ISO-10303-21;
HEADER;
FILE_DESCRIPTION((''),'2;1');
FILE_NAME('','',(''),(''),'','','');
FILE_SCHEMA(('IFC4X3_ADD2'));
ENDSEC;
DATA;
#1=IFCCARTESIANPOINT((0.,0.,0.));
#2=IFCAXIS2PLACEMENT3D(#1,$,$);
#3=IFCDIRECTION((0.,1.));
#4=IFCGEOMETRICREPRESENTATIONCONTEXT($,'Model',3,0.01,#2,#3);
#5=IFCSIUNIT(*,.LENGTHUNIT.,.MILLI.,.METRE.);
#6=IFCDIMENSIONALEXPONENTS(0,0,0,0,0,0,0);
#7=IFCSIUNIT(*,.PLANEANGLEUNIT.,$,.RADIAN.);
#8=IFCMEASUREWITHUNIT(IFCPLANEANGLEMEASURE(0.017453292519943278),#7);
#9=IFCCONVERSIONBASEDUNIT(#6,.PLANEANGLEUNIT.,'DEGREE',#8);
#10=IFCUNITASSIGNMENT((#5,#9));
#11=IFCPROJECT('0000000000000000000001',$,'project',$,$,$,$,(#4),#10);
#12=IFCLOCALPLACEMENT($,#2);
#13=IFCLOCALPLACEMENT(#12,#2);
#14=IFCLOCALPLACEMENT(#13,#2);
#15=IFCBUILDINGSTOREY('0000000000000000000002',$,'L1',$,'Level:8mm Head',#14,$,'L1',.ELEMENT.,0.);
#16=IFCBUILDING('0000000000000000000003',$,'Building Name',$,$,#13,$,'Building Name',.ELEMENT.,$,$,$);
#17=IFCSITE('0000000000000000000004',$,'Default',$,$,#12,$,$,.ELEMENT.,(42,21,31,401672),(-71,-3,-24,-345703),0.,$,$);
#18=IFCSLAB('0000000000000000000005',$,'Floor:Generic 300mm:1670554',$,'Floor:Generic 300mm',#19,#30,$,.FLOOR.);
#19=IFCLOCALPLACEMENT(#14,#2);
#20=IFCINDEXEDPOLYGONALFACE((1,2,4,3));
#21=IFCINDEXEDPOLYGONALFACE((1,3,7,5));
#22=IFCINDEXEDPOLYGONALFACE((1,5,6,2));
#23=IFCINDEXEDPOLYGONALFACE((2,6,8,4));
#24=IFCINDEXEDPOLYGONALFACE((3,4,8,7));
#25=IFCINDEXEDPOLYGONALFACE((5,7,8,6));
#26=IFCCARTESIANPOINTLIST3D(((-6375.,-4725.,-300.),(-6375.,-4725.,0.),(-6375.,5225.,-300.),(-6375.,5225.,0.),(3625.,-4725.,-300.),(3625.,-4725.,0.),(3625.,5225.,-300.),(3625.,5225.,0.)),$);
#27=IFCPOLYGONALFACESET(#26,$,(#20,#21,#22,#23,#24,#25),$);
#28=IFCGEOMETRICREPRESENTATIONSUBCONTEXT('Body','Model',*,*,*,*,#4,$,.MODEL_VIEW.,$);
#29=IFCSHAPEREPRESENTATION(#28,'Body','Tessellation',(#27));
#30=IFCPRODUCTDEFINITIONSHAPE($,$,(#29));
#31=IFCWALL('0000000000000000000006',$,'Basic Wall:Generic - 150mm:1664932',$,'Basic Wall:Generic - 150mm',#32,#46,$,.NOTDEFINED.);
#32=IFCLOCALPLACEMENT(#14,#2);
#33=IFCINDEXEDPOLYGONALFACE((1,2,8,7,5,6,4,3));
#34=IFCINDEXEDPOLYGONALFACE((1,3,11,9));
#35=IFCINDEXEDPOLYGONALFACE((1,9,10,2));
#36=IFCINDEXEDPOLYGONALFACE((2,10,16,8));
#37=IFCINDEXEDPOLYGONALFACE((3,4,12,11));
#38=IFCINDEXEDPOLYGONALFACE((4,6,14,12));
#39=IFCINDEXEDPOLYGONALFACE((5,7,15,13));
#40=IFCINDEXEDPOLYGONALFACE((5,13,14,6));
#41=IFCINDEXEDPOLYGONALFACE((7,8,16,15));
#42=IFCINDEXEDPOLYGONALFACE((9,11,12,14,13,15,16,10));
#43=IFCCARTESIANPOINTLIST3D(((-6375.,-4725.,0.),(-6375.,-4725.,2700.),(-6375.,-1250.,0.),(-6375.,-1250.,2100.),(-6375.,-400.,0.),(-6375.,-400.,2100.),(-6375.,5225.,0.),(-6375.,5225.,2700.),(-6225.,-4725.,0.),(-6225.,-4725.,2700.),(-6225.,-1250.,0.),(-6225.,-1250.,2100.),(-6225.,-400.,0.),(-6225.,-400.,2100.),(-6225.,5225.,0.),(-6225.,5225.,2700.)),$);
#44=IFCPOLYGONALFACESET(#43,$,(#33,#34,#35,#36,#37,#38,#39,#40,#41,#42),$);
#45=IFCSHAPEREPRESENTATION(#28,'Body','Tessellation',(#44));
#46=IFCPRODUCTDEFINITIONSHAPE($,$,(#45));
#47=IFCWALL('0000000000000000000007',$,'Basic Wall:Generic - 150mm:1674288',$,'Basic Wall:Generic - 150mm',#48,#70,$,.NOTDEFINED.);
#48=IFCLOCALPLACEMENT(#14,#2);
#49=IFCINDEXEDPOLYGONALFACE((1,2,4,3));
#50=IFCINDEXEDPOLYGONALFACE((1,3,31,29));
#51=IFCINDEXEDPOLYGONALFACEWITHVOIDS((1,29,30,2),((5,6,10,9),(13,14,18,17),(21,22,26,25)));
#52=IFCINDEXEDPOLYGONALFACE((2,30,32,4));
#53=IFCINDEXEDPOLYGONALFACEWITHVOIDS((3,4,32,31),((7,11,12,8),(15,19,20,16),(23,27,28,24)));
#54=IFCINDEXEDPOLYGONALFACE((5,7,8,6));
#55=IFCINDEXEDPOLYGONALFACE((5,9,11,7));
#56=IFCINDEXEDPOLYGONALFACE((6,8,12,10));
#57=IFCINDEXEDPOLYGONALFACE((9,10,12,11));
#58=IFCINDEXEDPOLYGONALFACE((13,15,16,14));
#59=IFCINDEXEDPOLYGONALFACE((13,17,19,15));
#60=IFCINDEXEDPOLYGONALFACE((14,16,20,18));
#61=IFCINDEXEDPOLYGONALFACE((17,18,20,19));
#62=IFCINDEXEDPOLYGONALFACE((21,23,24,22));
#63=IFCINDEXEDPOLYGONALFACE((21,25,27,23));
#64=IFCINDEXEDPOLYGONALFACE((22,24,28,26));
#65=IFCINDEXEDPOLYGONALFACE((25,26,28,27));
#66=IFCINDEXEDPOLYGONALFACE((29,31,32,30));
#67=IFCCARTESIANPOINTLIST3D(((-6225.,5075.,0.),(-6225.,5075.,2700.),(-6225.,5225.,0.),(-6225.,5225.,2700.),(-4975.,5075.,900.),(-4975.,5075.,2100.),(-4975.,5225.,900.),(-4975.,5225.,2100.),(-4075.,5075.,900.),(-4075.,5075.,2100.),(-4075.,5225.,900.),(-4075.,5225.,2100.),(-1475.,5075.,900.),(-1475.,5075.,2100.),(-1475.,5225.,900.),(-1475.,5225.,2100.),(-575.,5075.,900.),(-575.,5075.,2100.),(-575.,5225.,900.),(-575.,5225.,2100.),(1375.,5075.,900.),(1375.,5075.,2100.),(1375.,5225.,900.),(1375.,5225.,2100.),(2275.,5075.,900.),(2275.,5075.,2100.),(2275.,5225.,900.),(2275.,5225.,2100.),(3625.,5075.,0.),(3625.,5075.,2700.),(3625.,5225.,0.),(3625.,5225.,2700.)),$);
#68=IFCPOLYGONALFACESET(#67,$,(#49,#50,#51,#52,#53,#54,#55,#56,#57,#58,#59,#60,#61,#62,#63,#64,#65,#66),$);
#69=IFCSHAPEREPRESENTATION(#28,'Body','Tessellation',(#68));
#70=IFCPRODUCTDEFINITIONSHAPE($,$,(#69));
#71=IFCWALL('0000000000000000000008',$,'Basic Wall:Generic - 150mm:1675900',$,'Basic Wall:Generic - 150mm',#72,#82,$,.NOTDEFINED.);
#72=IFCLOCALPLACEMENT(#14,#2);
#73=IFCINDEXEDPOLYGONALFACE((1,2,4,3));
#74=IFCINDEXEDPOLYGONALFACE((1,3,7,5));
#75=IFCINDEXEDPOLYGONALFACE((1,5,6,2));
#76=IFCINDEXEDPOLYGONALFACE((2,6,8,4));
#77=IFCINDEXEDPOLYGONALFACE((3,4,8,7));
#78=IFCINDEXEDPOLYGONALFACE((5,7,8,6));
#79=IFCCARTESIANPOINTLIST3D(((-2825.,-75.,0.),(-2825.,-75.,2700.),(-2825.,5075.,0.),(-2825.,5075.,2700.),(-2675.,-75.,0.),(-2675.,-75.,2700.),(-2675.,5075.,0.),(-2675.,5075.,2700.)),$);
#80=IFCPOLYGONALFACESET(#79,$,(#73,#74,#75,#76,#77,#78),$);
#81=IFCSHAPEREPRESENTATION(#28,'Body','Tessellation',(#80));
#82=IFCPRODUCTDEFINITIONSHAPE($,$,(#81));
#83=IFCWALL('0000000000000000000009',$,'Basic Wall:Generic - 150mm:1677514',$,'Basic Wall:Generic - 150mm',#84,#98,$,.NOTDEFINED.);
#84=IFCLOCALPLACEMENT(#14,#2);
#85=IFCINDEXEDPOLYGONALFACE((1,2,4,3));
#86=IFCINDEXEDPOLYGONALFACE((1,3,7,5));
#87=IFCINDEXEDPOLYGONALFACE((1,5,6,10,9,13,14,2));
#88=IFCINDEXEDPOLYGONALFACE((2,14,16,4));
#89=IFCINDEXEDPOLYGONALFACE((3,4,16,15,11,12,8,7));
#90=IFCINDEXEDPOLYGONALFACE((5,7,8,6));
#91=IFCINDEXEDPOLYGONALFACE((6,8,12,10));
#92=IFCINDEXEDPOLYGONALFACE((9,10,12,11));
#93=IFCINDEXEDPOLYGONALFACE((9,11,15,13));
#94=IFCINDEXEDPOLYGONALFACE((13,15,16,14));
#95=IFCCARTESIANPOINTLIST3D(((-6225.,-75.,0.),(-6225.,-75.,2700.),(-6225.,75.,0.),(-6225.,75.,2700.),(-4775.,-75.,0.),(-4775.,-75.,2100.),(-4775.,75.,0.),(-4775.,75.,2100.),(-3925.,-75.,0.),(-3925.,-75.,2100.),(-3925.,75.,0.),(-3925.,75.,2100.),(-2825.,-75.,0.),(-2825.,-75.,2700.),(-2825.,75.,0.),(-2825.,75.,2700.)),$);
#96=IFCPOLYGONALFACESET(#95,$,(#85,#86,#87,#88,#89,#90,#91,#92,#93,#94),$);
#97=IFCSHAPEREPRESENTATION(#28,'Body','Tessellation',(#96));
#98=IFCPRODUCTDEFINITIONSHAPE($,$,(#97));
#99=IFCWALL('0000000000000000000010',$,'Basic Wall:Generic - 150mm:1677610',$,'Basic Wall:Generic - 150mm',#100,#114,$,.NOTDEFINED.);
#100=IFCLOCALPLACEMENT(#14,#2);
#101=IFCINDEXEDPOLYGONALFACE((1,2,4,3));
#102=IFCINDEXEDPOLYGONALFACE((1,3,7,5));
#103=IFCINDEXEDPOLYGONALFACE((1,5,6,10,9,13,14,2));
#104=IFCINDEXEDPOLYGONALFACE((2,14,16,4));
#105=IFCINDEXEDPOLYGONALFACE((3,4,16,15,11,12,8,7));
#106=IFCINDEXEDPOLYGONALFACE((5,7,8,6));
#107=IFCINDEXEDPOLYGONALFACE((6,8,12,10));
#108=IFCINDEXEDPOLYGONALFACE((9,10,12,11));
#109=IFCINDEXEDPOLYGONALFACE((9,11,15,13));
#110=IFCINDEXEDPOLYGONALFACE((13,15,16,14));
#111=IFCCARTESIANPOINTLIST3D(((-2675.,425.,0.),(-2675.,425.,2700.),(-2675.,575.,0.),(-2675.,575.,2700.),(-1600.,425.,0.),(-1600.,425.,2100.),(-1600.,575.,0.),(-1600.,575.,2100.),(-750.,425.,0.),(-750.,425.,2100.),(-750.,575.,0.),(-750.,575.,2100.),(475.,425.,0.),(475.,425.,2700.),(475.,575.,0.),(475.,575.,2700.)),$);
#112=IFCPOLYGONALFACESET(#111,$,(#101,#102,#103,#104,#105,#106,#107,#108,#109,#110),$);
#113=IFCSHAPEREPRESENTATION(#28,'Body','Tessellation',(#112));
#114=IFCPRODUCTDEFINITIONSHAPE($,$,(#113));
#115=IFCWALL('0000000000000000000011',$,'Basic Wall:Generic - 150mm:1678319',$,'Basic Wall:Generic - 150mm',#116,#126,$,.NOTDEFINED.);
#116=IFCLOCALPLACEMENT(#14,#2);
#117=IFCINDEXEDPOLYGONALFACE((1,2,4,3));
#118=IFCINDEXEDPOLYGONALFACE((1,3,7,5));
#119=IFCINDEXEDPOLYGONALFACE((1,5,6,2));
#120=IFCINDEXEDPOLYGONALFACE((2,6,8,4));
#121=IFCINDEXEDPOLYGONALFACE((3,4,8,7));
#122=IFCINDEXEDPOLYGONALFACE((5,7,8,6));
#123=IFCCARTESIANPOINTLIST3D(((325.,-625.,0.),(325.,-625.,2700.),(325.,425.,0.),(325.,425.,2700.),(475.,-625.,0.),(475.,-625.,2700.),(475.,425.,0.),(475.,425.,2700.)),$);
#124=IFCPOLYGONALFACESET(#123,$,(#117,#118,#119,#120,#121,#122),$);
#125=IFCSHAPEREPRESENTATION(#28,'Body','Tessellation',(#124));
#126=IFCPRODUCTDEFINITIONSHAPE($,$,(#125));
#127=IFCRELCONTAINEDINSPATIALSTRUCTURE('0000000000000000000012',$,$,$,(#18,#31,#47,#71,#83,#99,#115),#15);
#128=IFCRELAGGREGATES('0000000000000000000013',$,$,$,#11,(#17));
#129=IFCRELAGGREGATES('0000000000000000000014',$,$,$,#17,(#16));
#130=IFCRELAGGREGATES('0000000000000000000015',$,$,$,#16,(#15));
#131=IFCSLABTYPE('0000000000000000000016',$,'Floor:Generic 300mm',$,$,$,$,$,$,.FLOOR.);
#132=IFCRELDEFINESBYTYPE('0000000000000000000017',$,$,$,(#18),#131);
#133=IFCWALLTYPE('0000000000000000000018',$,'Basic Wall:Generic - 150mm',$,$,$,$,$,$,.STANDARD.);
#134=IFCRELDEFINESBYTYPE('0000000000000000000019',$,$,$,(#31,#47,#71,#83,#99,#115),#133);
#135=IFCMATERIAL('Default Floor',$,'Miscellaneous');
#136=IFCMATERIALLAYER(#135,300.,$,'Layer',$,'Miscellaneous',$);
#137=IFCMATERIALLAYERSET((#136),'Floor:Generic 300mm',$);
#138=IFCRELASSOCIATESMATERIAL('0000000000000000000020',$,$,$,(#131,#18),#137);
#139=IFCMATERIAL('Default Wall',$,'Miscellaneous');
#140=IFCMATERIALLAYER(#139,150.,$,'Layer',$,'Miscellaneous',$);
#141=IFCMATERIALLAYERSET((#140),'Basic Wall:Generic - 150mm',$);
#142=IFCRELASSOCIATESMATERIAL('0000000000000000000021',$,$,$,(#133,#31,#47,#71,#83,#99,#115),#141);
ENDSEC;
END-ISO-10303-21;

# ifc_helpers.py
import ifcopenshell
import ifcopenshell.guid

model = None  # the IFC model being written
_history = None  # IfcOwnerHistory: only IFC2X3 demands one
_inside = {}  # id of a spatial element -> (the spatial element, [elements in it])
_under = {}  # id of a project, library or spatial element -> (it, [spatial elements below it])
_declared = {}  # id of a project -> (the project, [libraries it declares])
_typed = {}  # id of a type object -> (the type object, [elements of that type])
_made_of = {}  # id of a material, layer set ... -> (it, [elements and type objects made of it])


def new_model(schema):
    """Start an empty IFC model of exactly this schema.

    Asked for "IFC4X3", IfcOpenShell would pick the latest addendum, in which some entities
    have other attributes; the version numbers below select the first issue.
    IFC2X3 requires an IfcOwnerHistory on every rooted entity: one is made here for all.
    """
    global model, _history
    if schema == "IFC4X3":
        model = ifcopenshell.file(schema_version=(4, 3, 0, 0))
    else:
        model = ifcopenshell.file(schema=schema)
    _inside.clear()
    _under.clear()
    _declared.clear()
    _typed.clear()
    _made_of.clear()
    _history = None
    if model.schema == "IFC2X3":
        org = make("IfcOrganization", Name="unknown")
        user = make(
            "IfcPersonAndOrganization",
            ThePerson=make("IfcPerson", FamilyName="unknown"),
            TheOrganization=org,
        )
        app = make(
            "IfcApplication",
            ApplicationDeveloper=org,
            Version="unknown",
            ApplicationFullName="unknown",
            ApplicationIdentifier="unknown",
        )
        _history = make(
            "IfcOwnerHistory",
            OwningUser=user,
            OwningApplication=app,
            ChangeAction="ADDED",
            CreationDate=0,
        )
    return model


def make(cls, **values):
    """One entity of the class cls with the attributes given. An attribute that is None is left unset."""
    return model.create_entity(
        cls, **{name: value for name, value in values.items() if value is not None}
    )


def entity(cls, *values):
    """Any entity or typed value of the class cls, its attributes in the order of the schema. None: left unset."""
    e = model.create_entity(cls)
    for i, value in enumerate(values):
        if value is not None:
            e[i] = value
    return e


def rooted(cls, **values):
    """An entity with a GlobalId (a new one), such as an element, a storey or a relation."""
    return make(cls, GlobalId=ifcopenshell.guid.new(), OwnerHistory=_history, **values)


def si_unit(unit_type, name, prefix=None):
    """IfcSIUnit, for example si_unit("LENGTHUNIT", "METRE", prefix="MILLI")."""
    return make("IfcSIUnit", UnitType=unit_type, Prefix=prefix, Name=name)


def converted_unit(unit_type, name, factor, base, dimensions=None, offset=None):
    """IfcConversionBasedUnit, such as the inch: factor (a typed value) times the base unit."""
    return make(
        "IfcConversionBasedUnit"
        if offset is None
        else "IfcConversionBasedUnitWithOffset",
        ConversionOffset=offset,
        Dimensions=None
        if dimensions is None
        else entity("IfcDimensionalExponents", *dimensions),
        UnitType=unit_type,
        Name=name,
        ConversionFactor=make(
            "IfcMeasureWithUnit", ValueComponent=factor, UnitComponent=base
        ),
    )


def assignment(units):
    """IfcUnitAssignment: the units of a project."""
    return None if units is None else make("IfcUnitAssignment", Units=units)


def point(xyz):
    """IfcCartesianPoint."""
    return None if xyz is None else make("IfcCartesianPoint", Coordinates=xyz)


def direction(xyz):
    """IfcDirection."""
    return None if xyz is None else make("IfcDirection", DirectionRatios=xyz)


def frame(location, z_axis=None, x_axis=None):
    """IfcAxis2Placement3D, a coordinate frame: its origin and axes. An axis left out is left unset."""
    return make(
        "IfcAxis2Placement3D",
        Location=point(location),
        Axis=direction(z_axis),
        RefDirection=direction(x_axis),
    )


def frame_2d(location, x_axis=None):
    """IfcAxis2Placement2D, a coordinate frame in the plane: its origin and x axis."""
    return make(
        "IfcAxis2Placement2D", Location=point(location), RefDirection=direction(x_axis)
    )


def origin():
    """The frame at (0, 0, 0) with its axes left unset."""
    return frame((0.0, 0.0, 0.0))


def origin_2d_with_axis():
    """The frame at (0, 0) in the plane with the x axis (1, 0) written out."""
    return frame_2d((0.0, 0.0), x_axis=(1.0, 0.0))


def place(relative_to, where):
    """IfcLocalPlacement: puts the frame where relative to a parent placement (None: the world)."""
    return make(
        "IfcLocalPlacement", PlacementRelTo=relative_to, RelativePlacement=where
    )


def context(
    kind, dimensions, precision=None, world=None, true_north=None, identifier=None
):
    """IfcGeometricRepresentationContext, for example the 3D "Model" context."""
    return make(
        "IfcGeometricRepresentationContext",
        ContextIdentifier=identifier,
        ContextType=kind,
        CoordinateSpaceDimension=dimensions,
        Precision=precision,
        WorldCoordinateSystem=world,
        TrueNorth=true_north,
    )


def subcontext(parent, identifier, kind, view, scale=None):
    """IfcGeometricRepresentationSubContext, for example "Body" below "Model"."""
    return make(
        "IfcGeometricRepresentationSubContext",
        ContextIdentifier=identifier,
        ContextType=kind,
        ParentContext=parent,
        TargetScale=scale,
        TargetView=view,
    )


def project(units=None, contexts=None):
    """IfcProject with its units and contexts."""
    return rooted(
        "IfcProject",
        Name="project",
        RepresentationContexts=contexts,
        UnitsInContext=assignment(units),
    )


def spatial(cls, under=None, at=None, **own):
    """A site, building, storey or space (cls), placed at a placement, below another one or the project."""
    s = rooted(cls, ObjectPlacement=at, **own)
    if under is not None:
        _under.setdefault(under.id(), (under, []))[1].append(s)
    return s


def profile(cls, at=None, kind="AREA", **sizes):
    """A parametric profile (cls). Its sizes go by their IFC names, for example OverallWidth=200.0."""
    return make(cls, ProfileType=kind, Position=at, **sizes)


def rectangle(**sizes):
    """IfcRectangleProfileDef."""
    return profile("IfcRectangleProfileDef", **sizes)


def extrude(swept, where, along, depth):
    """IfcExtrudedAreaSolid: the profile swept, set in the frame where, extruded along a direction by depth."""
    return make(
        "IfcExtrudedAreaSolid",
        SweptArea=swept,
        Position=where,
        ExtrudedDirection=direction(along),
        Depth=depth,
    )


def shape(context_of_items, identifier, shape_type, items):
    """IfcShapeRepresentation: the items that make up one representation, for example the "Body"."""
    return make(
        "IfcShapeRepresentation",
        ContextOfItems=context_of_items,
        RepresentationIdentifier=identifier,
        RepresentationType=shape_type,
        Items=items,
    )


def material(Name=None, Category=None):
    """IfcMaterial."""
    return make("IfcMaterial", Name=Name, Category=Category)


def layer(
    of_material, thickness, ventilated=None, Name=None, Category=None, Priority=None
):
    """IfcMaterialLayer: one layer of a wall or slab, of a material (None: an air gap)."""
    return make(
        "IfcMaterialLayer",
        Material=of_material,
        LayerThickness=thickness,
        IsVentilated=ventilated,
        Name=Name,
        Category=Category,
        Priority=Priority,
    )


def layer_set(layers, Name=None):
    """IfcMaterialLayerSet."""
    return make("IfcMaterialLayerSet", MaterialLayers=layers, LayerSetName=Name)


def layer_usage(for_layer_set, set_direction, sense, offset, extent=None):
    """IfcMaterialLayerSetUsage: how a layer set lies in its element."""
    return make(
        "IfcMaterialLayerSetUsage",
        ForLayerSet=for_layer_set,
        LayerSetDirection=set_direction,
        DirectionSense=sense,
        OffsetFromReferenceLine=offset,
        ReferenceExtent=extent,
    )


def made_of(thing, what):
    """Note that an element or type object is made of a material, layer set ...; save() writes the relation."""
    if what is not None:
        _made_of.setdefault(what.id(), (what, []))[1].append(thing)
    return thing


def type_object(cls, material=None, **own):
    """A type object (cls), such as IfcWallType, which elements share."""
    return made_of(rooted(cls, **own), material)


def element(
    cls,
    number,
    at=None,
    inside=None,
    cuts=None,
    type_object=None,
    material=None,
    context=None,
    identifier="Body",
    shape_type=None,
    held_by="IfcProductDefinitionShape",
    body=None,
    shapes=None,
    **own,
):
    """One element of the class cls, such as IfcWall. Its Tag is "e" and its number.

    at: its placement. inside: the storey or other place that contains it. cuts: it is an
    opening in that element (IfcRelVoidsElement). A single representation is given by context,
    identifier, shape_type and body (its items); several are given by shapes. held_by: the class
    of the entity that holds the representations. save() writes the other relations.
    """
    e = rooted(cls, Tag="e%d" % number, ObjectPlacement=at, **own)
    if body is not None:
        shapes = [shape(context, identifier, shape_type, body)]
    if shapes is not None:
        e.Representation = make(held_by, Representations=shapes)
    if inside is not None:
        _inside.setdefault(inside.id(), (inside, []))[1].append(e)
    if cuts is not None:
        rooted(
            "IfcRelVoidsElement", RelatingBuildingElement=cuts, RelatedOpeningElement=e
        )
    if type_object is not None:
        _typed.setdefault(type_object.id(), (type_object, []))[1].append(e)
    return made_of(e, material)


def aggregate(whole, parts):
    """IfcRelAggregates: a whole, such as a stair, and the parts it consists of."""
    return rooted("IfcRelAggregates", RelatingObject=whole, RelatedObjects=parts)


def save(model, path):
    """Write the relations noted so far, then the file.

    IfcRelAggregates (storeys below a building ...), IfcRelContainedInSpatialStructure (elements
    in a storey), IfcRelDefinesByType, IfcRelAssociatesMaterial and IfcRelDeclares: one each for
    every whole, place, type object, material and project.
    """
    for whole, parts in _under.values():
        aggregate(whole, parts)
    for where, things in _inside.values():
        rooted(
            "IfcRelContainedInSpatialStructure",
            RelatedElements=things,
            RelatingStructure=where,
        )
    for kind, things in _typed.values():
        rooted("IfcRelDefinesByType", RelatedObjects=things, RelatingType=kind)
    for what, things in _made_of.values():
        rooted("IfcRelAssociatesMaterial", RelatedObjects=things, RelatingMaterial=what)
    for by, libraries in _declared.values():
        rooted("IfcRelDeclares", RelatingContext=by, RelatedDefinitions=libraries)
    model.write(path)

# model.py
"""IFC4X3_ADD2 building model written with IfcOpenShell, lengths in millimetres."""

from ifc_helpers import new_model, entity, si_unit, converted_unit, direction, frame, frame_2d, origin, origin_2d_with_axis, place, context, subcontext, project, spatial, rectangle, extrude, material, layer, layer_set, layer_usage, type_object, element, save


model = new_model("IFC4X3_ADD2")

# Units and contexts
model_context = context("Model", 3, precision=0.01, world=origin(), true_north=direction((0.0, 1.0)))
body_context = subcontext(model_context, "Body", "Model", "MODEL_VIEW")
ifc_project = project(units=[si_unit("LENGTHUNIT", "METRE", prefix="MILLI"), converted_unit("PLANEANGLEUNIT", "DEGREE", entity("IfcPlaneAngleMeasure", 0.017453292519943278), si_unit("PLANEANGLEUNIT", "RADIAN"), dimensions=[0, 0, 0, 0, 0, 0, 0])], contexts=[model_context])

# Site, building, storey
site_placement = place(None, origin())
site = spatial("IfcSite", under=ifc_project, at=site_placement, Name="Default", CompositionType="ELEMENT", RefLatitude=(42, 21, 31, 401672), RefLongitude=(-71, -3, -24, -345703), RefElevation=0.0)
building_placement = place(site_placement, origin())
building = spatial("IfcBuilding", under=site, at=building_placement, Name="Building Name", LongName="Building Name", CompositionType="ELEMENT")
storey_placement = place(building_placement, origin())
storey = spatial("IfcBuildingStorey", under=building, at=storey_placement, Name="L1", ObjectType="Level:8mm Head", LongName="L1", CompositionType="ELEMENT", Elevation=0.0)

# Slab
ifc_material_1 = material(Name="Default Floor", Category="Miscellaneous")
ifc_layer_1 = layer(ifc_material_1, 300.0, Name="Layer", Category="Miscellaneous")
ifc_layer_set_1 = layer_set([ifc_layer_1], Name="Floor:Generic 300mm")
ifc_layer_usage = layer_usage(ifc_layer_set_1, "AXIS3", "POSITIVE", 0.0)
slab_type = type_object("IfcSlabType", Name="Floor:Generic 300mm", PredefinedType="FLOOR", material=ifc_layer_set_1)
slab_placement = place(storey_placement, origin())
element("IfcSlab", 1, at=slab_placement, inside=storey, type_object=slab_type, material=ifc_layer_usage, Name="Floor:Generic 300mm:1670554", ObjectType="Floor:Generic 300mm", PredefinedType="FLOOR", context=body_context, shape_type="SweptSolid", body=[
    extrude(rectangle(XDim=9950.0, YDim=10000.0, at=origin_2d_with_axis()), frame((-1375.0, 250.0, 0.0), z_axis=(0.0, 0.0, -1.0), x_axis=(0.0, 1.0, 0.0)), (0.0, 0.0, 1.0), 300.0),
])

# Wall, opening
ifc_material_2 = material(Name="Default Wall", Category="Miscellaneous")
ifc_layer_2 = layer(ifc_material_2, 150.0, Name="Layer", Category="Miscellaneous")
ifc_layer_set_2 = layer_set([ifc_layer_2], Name="Basic Wall:Generic - 150mm")
wall_type = type_object("IfcWallType", Name="Basic Wall:Generic - 150mm", PredefinedType="STANDARD", material=ifc_layer_set_2)
wall_1_placement = place(storey_placement, frame((-6300.0, 5225.0, 0.0), z_axis=(0.0, 0.0, 1.0), x_axis=(0.0, -1.0, 0.0)))
wall_1 = element("IfcWall", 2, at=wall_1_placement, inside=storey, type_object=wall_type, material=ifc_layer_set_2, Name="Basic Wall:Generic - 150mm:1664932", ObjectType="Basic Wall:Generic - 150mm", PredefinedType="NOTDEFINED", context=body_context, shape_type="SweptSolid", body=[
    extrude(rectangle(XDim=9950.0, YDim=150.0, at=frame_2d((4975.0, 0.0), x_axis=(-1.0, 0.0))), origin(), (0.0, 0.0, 1.0), 2700.0),
])
opening_1_placement = place(wall_1_placement, frame((6475.0, 75.0, 0.0)))
element("IfcOpeningElement", 3, at=opening_1_placement, cuts=wall_1, PredefinedType="OPENING", context=body_context, shape_type="SweptSolid", body=[
    extrude(rectangle(XDim=2100.0, YDim=850.0, at=frame_2d((1050.0, 425.0), x_axis=(1.0, 0.0))), frame((0.0, 0.0, 0.0), z_axis=(0.0, -1.0, 0.0), x_axis=(0.0, 0.0, 1.0)), (0.0, 0.0, 1.0), 150.0),
])

# Wall, openings
wall_2_placement = place(storey_placement, frame((-6225.0, 5150.0, 0.0)))
wall_2 = element("IfcWall", 4, at=wall_2_placement, inside=storey, type_object=wall_type, material=ifc_layer_set_2, Name="Basic Wall:Generic - 150mm:1674288", ObjectType="Basic Wall:Generic - 150mm", PredefinedType="NOTDEFINED", context=body_context, shape_type="SweptSolid", body=[
    extrude(rectangle(XDim=9850.0, YDim=150.0, at=frame_2d((4925.0, 0.0), x_axis=(-1.0, 0.0))), origin(), (0.0, 0.0, 1.0), 2700.0),
])
opening_2_placement = place(wall_2_placement, frame((1250.0, -75.0, 900.0)))
element("IfcOpeningElement", 5, at=opening_2_placement, cuts=wall_2, PredefinedType="OPENING", context=body_context, shape_type="SweptSolid", body=[
    extrude(rectangle(XDim=1200.0, YDim=900.0, at=frame_2d((600.0, 450.0), x_axis=(-1.0, 0.0))), frame((0.0, 0.0, 0.0), z_axis=(0.0, 1.0, 0.0), x_axis=(0.0, 0.0, 1.0)), (0.0, 0.0, 1.0), 150.0),
])
opening_3_placement = place(wall_2_placement, frame((4750.0, -75.0, 900.0)))
element("IfcOpeningElement", 6, at=opening_3_placement, cuts=wall_2, PredefinedType="OPENING", context=body_context, shape_type="SweptSolid", body=[
    extrude(rectangle(XDim=1200.0, YDim=900.0, at=frame_2d((600.0, 450.0), x_axis=(-1.0, 0.0))), frame((0.0, 0.0, 0.0), z_axis=(0.0, 1.0, 0.0), x_axis=(0.0, 0.0, 1.0)), (0.0, 0.0, 1.0), 150.0),
])
opening_4_placement = place(wall_2_placement, frame((7600.0, -75.0, 900.0)))
element("IfcOpeningElement", 7, at=opening_4_placement, cuts=wall_2, PredefinedType="OPENING", context=body_context, shape_type="SweptSolid", body=[
    extrude(rectangle(XDim=1200.0, YDim=900.0, at=frame_2d((600.0, 450.0), x_axis=(-1.0, 0.0))), frame((0.0, 0.0, 0.0), z_axis=(0.0, 1.0, 0.0), x_axis=(0.0, 0.0, 1.0)), (0.0, 0.0, 1.0), 150.0),
])

# Wall
wall_3_placement = place(storey_placement, frame((-2750.0, -75.0, 0.0), z_axis=(0.0, 0.0, 1.0), x_axis=(0.0, 1.0, 0.0)))
element("IfcWall", 8, at=wall_3_placement, inside=storey, type_object=wall_type, material=ifc_layer_set_2, Name="Basic Wall:Generic - 150mm:1675900", ObjectType="Basic Wall:Generic - 150mm", PredefinedType="NOTDEFINED", context=body_context, shape_type="SweptSolid", body=[
    extrude(rectangle(XDim=5150.0, YDim=150.0, at=frame_2d((2575.0, 0.0), x_axis=(-1.0, 0.0))), origin(), (0.0, 0.0, 1.0), 2700.0),
])

# Walls, openings
wall_4_placement = place(storey_placement, frame((-2825.0, 0.0, 0.0), z_axis=(0.0, 0.0, 1.0), x_axis=(-1.0, 0.0, 0.0)))
wall_4 = element("IfcWall", 9, at=wall_4_placement, inside=storey, type_object=wall_type, material=ifc_layer_set_2, Name="Basic Wall:Generic - 150mm:1677514", ObjectType="Basic Wall:Generic - 150mm", PredefinedType="NOTDEFINED", context=body_context, shape_type="SweptSolid", body=[
    extrude(rectangle(XDim=3400.0, YDim=150.0, at=frame_2d((1700.0, 0.0), x_axis=(1.0, 0.0))), origin(), (0.0, 0.0, 1.0), 2700.0),
])
opening_5_placement = place(wall_4_placement, frame((1950.0, 75.0, 0.0)))
element("IfcOpeningElement", 10, at=opening_5_placement, cuts=wall_4, PredefinedType="OPENING", context=body_context, shape_type="SweptSolid", body=[
    extrude(rectangle(XDim=2100.0, YDim=850.0, at=frame_2d((1050.0, 425.0), x_axis=(1.0, 0.0))), frame((0.0, 0.0, 0.0), z_axis=(0.0, -1.0, 0.0), x_axis=(0.0, 0.0, 1.0)), (0.0, 0.0, 1.0), 150.0),
])
wall_5_placement = place(storey_placement, frame((-2675.0, 500.0, 0.0)))
wall_5 = element("IfcWall", 11, at=wall_5_placement, inside=storey, type_object=wall_type, material=ifc_layer_set_2, Name="Basic Wall:Generic - 150mm:1677610", ObjectType="Basic Wall:Generic - 150mm", PredefinedType="NOTDEFINED", context=body_context, shape_type="SweptSolid", body=[
    extrude(rectangle(XDim=3150.0, YDim=150.0, at=frame_2d((1575.0, 0.0), x_axis=(-1.0, 0.0))), origin(), (0.0, 0.0, 1.0), 2700.0),
])
opening_6_placement = place(wall_5_placement, frame((1075.0, -75.0, 0.0)))
element("IfcOpeningElement", 12, at=opening_6_placement, cuts=wall_5, PredefinedType="OPENING", context=body_context, shape_type="SweptSolid", body=[
    extrude(rectangle(XDim=2100.0, YDim=850.0, at=frame_2d((1050.0, 425.0), x_axis=(1.0, 0.0))), frame((0.0, 0.0, 0.0), z_axis=(0.0, 1.0, 0.0), x_axis=(0.0, 0.0, 1.0)), (0.0, 0.0, 1.0), 150.0),
])

# Wall
wall_6_placement = place(storey_placement, frame((400.0, -625.0, 0.0), z_axis=(0.0, 0.0, 1.0), x_axis=(0.0, 1.0, 0.0)))
element("IfcWall", 13, at=wall_6_placement, inside=storey, type_object=wall_type, material=ifc_layer_set_2, Name="Basic Wall:Generic - 150mm:1678319", ObjectType="Basic Wall:Generic - 150mm", PredefinedType="NOTDEFINED", context=body_context, shape_type="SweptSolid", body=[
    extrude(rectangle(XDim=1050.0, YDim=150.0, at=frame_2d((525.0, 0.0), x_axis=(-1.0, 0.0))), origin(), (0.0, 0.0, 1.0), 2700.0),
])

save(model, "model.ifc")
